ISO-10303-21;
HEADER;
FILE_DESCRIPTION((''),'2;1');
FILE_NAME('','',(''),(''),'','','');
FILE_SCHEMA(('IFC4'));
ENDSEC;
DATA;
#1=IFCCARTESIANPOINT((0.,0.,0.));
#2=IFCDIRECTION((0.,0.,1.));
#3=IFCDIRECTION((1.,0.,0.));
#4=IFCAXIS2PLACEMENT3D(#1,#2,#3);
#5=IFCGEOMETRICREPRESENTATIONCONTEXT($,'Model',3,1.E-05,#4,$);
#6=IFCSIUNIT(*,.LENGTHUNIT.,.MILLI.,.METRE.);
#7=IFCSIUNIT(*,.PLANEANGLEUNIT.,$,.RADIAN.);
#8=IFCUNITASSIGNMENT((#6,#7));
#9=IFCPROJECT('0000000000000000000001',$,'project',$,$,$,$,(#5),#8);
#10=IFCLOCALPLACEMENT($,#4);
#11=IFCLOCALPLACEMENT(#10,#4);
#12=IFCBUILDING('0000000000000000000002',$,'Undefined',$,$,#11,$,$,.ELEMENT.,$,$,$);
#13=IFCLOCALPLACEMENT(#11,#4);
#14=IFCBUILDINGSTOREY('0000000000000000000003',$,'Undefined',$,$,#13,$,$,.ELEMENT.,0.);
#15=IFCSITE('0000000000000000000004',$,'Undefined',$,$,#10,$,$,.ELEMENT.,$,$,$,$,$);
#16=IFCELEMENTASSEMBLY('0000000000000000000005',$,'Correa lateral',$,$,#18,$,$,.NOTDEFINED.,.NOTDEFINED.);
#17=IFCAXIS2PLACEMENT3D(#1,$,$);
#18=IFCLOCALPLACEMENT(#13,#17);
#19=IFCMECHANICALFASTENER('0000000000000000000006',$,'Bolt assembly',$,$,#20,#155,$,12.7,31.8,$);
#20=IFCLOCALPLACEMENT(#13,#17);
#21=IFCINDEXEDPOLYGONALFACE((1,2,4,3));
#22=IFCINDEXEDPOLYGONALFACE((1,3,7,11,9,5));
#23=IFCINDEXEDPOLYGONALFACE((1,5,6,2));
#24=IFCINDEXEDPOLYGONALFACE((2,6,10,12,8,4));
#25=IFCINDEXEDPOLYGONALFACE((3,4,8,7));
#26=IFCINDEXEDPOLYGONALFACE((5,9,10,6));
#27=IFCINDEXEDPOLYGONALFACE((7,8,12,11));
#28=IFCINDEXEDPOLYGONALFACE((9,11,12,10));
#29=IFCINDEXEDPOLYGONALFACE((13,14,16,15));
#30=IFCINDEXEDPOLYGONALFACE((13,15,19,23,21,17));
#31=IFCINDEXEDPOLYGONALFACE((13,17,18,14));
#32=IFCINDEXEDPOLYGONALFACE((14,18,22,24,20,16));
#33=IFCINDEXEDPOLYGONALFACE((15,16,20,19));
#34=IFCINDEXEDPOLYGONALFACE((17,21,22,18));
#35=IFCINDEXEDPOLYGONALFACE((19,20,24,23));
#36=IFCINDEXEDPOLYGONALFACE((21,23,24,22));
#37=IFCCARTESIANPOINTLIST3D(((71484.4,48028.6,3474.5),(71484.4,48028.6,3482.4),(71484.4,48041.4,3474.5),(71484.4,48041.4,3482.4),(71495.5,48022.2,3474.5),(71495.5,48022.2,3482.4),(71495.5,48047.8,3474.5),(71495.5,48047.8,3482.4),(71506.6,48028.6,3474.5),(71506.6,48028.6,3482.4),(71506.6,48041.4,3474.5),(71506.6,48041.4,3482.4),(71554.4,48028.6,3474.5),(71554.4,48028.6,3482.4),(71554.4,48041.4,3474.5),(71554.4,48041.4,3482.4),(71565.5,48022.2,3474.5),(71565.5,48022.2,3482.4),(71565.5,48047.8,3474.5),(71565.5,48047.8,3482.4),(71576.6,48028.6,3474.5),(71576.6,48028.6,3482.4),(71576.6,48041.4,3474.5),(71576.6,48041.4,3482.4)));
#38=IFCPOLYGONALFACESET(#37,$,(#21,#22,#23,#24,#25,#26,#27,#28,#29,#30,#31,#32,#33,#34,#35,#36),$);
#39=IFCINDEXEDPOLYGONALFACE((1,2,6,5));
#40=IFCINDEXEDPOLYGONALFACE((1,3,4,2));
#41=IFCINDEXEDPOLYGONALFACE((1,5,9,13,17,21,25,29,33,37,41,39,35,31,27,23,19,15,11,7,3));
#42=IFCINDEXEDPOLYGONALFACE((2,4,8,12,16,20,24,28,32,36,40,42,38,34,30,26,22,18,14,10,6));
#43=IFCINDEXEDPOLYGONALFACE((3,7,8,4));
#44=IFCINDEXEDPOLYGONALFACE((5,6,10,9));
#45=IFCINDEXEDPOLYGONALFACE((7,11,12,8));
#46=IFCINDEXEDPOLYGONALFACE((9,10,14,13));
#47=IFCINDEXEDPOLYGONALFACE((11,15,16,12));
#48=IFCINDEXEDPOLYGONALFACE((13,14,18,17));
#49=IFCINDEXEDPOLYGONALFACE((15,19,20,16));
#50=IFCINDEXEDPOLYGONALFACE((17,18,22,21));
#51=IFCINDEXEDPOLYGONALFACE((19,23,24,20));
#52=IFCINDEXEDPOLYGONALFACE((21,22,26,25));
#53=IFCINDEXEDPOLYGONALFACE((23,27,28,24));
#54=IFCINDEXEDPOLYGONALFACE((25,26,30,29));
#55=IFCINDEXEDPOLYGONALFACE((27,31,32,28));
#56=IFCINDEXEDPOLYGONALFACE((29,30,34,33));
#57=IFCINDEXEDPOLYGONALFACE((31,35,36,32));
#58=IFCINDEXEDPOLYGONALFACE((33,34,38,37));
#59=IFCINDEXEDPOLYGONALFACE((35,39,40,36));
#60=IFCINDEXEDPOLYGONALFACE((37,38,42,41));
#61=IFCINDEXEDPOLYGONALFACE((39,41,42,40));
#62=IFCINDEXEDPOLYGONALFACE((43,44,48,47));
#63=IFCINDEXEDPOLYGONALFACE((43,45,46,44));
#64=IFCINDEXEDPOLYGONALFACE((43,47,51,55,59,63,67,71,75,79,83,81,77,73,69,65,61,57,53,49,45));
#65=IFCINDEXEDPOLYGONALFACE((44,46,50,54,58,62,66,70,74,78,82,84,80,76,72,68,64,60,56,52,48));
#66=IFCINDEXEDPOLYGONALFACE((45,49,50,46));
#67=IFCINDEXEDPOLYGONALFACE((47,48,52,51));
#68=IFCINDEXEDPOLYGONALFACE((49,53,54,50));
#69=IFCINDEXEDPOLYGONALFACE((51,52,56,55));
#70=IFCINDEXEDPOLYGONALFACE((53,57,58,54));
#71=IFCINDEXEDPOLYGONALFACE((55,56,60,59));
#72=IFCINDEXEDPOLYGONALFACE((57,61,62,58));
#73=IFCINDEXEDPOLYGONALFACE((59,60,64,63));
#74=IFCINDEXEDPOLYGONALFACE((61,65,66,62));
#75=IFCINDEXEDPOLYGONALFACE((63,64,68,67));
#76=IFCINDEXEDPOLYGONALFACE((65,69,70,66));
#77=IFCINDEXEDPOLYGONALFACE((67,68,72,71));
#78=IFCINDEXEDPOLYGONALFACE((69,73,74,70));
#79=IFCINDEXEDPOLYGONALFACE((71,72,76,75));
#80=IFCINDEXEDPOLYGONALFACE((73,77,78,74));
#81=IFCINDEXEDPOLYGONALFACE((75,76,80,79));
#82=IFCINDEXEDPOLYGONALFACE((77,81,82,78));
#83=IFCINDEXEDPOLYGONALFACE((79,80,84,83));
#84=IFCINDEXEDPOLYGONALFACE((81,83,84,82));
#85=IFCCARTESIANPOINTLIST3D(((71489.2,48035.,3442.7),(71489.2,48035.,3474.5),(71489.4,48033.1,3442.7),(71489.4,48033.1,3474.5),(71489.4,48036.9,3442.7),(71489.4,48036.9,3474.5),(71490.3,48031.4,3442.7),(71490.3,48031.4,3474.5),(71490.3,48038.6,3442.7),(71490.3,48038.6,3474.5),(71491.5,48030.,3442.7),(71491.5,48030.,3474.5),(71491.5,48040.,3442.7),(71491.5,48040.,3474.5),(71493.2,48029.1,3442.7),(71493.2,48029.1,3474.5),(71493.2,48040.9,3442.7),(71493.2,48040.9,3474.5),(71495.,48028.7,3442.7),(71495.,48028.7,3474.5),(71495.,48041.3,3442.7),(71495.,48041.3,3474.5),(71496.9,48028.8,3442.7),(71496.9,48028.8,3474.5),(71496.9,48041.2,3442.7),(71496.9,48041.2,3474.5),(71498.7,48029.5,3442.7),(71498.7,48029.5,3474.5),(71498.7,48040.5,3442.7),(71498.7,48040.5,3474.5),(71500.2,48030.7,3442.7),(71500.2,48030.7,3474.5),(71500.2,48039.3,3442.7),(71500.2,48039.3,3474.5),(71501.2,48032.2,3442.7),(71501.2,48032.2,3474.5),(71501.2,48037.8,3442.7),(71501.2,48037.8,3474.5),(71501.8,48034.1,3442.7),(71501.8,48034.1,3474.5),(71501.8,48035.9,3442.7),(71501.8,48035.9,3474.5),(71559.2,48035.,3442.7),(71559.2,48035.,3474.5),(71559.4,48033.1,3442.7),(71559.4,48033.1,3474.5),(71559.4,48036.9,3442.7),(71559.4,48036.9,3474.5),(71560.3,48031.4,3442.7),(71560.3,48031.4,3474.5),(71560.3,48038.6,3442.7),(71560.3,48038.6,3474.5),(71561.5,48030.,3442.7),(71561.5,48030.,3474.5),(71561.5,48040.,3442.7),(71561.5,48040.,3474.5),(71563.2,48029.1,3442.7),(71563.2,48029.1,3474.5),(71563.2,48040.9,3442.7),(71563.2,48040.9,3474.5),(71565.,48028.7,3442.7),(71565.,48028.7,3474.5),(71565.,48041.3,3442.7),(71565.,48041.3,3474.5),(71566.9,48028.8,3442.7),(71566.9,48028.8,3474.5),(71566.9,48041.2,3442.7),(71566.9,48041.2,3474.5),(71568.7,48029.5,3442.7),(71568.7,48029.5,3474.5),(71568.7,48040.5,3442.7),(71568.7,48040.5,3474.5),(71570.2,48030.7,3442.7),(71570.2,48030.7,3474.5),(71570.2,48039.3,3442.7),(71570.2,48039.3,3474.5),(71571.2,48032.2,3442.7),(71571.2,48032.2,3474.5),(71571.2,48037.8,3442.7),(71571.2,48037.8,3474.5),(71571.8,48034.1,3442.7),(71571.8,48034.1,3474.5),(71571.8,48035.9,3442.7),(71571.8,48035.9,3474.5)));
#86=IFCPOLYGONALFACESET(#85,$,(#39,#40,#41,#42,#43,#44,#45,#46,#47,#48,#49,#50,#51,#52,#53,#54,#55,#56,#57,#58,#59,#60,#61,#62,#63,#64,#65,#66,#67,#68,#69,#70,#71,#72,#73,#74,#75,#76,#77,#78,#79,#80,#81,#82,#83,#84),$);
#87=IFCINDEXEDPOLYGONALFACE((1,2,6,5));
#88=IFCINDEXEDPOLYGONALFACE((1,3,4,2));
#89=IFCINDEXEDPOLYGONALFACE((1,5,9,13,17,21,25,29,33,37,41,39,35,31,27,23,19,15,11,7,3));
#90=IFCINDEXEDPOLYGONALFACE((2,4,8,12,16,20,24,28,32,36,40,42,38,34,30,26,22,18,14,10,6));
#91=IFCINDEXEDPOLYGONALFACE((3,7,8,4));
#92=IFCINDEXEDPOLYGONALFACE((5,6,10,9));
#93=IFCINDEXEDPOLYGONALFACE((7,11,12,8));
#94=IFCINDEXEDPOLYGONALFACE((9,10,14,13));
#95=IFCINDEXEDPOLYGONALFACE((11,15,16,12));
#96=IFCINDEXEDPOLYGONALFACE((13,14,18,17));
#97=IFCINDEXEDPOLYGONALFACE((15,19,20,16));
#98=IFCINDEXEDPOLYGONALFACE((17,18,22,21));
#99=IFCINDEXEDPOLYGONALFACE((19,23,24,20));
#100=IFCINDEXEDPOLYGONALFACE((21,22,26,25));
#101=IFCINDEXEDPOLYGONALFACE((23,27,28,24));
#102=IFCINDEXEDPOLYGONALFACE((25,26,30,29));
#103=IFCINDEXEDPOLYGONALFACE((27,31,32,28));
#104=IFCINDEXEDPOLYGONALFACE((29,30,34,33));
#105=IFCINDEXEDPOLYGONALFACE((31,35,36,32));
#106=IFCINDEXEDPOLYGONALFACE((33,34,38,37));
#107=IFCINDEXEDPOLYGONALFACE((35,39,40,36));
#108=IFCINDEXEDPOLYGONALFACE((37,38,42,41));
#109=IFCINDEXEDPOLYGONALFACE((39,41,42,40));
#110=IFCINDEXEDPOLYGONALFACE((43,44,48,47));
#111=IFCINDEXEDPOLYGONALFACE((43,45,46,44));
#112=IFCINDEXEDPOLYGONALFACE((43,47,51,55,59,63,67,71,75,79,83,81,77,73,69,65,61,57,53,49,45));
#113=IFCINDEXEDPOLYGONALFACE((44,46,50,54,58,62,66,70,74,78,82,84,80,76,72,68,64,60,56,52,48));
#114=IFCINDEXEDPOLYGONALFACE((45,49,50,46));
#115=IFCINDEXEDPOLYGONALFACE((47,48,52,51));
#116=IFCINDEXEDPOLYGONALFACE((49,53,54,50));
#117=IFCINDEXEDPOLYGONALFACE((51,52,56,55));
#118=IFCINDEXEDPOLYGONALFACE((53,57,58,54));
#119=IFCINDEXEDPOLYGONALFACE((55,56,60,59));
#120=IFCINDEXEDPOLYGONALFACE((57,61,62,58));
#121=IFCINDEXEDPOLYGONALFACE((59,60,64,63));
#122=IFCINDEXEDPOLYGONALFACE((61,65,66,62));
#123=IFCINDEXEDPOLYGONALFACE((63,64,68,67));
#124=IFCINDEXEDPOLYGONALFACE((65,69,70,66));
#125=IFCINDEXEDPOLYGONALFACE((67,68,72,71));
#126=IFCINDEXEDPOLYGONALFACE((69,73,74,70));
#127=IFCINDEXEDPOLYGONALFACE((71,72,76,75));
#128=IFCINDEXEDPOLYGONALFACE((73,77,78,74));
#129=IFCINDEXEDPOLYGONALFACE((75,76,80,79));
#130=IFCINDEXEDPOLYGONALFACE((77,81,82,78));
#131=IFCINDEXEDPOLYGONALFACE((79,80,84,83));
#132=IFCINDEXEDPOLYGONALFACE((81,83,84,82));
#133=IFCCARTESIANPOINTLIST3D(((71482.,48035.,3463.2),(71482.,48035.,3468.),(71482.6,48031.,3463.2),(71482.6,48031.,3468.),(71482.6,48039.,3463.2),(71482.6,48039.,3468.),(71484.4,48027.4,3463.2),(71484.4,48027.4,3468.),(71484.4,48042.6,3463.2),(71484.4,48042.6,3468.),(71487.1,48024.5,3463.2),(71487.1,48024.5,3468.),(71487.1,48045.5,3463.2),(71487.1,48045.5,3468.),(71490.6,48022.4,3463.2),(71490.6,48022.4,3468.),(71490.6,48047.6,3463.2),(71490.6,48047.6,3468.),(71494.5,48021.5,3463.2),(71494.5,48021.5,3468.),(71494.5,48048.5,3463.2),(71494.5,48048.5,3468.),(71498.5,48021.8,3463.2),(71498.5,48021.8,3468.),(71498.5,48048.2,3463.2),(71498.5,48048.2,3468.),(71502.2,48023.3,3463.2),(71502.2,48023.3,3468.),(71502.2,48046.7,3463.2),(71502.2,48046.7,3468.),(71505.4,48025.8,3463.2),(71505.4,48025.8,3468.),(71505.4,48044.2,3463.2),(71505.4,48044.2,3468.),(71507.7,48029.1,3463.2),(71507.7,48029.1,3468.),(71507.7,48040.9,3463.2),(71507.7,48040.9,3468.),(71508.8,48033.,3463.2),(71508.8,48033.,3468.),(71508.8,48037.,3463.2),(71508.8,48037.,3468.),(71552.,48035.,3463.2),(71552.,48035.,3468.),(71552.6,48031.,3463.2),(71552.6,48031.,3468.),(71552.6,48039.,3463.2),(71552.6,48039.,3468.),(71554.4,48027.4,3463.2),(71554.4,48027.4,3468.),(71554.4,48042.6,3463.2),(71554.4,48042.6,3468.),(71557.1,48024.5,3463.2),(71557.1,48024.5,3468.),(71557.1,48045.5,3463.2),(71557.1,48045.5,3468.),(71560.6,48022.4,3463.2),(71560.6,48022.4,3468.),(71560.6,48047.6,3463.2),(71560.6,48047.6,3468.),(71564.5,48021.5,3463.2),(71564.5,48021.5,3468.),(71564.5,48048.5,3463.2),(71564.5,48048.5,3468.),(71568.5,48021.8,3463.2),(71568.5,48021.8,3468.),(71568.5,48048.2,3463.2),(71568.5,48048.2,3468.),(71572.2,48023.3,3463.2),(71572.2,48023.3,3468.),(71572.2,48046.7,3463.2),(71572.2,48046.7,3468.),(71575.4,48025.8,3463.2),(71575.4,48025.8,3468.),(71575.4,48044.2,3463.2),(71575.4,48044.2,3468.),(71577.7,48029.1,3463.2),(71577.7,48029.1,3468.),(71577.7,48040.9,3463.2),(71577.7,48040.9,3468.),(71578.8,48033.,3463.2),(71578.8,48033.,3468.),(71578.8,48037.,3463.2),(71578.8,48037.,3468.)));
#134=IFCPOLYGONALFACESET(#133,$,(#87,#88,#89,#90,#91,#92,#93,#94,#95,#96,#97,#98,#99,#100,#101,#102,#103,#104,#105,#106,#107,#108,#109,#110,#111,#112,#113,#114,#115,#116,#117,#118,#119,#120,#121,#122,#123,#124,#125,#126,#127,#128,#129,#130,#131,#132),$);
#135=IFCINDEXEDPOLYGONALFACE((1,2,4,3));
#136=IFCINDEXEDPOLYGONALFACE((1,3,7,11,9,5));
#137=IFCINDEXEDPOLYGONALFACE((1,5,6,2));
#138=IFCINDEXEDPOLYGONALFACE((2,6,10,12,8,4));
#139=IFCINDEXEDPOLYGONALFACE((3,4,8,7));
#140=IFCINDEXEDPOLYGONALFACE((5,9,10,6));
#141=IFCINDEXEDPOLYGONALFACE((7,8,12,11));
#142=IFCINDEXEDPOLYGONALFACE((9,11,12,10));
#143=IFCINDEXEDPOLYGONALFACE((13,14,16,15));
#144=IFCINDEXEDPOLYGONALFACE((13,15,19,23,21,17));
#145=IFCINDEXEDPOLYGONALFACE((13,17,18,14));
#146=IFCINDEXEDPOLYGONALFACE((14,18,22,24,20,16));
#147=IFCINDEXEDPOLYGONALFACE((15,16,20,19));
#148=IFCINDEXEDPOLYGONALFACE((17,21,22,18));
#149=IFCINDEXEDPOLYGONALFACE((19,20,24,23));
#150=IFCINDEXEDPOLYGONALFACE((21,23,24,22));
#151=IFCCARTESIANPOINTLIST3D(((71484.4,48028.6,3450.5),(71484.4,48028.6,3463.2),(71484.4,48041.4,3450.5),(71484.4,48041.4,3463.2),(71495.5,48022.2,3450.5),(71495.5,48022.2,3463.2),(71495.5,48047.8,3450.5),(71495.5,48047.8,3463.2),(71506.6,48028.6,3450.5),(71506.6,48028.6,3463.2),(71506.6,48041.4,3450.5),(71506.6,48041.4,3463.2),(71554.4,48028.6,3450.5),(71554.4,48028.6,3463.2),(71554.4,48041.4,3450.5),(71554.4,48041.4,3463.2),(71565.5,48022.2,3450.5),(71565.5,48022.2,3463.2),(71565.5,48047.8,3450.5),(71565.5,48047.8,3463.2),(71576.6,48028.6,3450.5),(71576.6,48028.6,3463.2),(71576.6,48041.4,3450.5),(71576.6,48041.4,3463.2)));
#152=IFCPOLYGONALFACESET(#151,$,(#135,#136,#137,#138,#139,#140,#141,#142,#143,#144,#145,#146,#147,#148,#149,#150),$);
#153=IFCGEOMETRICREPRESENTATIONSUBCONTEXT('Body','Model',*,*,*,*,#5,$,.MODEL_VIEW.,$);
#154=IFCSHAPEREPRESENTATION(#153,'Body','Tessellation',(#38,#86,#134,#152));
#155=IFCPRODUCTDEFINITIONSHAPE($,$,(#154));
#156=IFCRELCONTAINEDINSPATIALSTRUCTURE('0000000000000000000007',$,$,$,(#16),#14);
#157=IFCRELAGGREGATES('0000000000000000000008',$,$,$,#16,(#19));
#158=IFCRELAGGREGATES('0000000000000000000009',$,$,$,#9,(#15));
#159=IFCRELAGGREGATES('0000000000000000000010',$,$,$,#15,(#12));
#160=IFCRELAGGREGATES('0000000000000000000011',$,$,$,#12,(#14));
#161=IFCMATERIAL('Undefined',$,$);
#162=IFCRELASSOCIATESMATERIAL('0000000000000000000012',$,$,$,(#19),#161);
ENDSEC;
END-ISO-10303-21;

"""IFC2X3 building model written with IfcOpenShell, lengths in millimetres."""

from ifc_helpers import new_model, si_unit, frame, origin_with_axes, origin_2d_with_axis, place, context, subcontext, project, spatial, polyline, circle, outline, extrude, source, transform, mapped, material, element, aggregate, save


model = new_model("IFC2X3")

# Units and contexts
model_context = context("Model", 3, precision=1e-05, world=origin_with_axes())
body_context = subcontext(model_context, "Body", "Model", "MODEL_VIEW")
ifc_project = project(units=[si_unit("LENGTHUNIT", "METRE", prefix="MILLI"), si_unit("PLANEANGLEUNIT", "RADIAN")], contexts=[model_context])

# Site, building, storey
site_placement = place(None, origin_with_axes())
site = spatial("IfcSite", under=ifc_project, at=site_placement, Name="Undefined", CompositionType="ELEMENT")
building_placement = place(site_placement, origin_with_axes())
building = spatial("IfcBuilding", under=site, at=building_placement, Name="Undefined", CompositionType="ELEMENT")
storey_placement = place(building_placement, origin_with_axes())
storey = spatial("IfcBuildingStorey", under=building, at=storey_placement, Name="Undefined", CompositionType="ELEMENT", Elevation=0.0)

# Element assembly
assembly_1_placement = place(storey_placement, origin_with_axes())
assembly_1 = element("IfcElementAssembly", 1, at=assembly_1_placement, inside=storey, Name="Correa lateral", AssemblyPlace="NOTDEFINED", PredefinedType="NOTDEFINED")

# Mechanical fastener
ifc_material_1 = material(Name="Undefined")
shared_shape_1 = source(origin_with_axes(), body_context, "Body", "SweptSolid", [
    extrude(outline(polyline([(11.1, -6.4), (11.1, 6.4), (0.0, 12.8), (-11.1, 6.4), (-11.1, -6.4), (0.0, -12.8), (11.1, -6.4)])), frame((0.0, -12.4, 0.0), z_axis=(0.0, 1.0, 0.0), x_axis=(1.0, 0.0, 0.0)), (0.0, 0.0, 1.0), 7.9),
    extrude(circle(Radius=6.3, at=origin_2d_with_axis()), frame((0.0, -4.5, 0.0), z_axis=(0.0, 1.0, 0.0), x_axis=(1.0, 0.0, 0.0)), (0.0, 0.0, 1.0), 31.8),
    extrude(circle(Radius=13.5, at=origin_2d_with_axis()), frame((0.0, 2.0, 0.0), z_axis=(0.0, 1.0, 0.0), x_axis=(1.0, 0.0, 0.0)), (0.0, 0.0, 1.0), 4.8),
    extrude(outline(polyline([(11.1, -6.4), (11.1, 6.4), (0.0, 12.8), (-11.1, 6.4), (-11.1, -6.4), (0.0, -12.8), (11.1, -6.4)])), frame((0.0, 6.8, 0.0), z_axis=(0.0, 1.0, 0.0), x_axis=(1.0, 0.0, 0.0)), (0.0, 0.0, 1.0), 12.7),
])
mechanical_fastener_1_placement = place(assembly_1_placement, frame((71565.5, 48035.0, 3470.0), z_axis=(0.0, -1.0, 0.0), x_axis=(-1.0, 0.0, 0.0)))
mechanical_fastener_1 = element("IfcMechanicalFastener", 2, at=mechanical_fastener_1_placement, material=ifc_material_1, Name="Bolt assembly", NominalDiameter=12.7, NominalLength=31.8, context=body_context, shape_type="MappedRepresentation", body=[
    mapped(shared_shape_1, transform((0.0, 0.0, 0.0))),
    mapped(shared_shape_1, transform((70.0, 0.0, 0.0))),
])
aggregate(assembly_1, [mechanical_fastener_1])

save(model, "model.ifc")
